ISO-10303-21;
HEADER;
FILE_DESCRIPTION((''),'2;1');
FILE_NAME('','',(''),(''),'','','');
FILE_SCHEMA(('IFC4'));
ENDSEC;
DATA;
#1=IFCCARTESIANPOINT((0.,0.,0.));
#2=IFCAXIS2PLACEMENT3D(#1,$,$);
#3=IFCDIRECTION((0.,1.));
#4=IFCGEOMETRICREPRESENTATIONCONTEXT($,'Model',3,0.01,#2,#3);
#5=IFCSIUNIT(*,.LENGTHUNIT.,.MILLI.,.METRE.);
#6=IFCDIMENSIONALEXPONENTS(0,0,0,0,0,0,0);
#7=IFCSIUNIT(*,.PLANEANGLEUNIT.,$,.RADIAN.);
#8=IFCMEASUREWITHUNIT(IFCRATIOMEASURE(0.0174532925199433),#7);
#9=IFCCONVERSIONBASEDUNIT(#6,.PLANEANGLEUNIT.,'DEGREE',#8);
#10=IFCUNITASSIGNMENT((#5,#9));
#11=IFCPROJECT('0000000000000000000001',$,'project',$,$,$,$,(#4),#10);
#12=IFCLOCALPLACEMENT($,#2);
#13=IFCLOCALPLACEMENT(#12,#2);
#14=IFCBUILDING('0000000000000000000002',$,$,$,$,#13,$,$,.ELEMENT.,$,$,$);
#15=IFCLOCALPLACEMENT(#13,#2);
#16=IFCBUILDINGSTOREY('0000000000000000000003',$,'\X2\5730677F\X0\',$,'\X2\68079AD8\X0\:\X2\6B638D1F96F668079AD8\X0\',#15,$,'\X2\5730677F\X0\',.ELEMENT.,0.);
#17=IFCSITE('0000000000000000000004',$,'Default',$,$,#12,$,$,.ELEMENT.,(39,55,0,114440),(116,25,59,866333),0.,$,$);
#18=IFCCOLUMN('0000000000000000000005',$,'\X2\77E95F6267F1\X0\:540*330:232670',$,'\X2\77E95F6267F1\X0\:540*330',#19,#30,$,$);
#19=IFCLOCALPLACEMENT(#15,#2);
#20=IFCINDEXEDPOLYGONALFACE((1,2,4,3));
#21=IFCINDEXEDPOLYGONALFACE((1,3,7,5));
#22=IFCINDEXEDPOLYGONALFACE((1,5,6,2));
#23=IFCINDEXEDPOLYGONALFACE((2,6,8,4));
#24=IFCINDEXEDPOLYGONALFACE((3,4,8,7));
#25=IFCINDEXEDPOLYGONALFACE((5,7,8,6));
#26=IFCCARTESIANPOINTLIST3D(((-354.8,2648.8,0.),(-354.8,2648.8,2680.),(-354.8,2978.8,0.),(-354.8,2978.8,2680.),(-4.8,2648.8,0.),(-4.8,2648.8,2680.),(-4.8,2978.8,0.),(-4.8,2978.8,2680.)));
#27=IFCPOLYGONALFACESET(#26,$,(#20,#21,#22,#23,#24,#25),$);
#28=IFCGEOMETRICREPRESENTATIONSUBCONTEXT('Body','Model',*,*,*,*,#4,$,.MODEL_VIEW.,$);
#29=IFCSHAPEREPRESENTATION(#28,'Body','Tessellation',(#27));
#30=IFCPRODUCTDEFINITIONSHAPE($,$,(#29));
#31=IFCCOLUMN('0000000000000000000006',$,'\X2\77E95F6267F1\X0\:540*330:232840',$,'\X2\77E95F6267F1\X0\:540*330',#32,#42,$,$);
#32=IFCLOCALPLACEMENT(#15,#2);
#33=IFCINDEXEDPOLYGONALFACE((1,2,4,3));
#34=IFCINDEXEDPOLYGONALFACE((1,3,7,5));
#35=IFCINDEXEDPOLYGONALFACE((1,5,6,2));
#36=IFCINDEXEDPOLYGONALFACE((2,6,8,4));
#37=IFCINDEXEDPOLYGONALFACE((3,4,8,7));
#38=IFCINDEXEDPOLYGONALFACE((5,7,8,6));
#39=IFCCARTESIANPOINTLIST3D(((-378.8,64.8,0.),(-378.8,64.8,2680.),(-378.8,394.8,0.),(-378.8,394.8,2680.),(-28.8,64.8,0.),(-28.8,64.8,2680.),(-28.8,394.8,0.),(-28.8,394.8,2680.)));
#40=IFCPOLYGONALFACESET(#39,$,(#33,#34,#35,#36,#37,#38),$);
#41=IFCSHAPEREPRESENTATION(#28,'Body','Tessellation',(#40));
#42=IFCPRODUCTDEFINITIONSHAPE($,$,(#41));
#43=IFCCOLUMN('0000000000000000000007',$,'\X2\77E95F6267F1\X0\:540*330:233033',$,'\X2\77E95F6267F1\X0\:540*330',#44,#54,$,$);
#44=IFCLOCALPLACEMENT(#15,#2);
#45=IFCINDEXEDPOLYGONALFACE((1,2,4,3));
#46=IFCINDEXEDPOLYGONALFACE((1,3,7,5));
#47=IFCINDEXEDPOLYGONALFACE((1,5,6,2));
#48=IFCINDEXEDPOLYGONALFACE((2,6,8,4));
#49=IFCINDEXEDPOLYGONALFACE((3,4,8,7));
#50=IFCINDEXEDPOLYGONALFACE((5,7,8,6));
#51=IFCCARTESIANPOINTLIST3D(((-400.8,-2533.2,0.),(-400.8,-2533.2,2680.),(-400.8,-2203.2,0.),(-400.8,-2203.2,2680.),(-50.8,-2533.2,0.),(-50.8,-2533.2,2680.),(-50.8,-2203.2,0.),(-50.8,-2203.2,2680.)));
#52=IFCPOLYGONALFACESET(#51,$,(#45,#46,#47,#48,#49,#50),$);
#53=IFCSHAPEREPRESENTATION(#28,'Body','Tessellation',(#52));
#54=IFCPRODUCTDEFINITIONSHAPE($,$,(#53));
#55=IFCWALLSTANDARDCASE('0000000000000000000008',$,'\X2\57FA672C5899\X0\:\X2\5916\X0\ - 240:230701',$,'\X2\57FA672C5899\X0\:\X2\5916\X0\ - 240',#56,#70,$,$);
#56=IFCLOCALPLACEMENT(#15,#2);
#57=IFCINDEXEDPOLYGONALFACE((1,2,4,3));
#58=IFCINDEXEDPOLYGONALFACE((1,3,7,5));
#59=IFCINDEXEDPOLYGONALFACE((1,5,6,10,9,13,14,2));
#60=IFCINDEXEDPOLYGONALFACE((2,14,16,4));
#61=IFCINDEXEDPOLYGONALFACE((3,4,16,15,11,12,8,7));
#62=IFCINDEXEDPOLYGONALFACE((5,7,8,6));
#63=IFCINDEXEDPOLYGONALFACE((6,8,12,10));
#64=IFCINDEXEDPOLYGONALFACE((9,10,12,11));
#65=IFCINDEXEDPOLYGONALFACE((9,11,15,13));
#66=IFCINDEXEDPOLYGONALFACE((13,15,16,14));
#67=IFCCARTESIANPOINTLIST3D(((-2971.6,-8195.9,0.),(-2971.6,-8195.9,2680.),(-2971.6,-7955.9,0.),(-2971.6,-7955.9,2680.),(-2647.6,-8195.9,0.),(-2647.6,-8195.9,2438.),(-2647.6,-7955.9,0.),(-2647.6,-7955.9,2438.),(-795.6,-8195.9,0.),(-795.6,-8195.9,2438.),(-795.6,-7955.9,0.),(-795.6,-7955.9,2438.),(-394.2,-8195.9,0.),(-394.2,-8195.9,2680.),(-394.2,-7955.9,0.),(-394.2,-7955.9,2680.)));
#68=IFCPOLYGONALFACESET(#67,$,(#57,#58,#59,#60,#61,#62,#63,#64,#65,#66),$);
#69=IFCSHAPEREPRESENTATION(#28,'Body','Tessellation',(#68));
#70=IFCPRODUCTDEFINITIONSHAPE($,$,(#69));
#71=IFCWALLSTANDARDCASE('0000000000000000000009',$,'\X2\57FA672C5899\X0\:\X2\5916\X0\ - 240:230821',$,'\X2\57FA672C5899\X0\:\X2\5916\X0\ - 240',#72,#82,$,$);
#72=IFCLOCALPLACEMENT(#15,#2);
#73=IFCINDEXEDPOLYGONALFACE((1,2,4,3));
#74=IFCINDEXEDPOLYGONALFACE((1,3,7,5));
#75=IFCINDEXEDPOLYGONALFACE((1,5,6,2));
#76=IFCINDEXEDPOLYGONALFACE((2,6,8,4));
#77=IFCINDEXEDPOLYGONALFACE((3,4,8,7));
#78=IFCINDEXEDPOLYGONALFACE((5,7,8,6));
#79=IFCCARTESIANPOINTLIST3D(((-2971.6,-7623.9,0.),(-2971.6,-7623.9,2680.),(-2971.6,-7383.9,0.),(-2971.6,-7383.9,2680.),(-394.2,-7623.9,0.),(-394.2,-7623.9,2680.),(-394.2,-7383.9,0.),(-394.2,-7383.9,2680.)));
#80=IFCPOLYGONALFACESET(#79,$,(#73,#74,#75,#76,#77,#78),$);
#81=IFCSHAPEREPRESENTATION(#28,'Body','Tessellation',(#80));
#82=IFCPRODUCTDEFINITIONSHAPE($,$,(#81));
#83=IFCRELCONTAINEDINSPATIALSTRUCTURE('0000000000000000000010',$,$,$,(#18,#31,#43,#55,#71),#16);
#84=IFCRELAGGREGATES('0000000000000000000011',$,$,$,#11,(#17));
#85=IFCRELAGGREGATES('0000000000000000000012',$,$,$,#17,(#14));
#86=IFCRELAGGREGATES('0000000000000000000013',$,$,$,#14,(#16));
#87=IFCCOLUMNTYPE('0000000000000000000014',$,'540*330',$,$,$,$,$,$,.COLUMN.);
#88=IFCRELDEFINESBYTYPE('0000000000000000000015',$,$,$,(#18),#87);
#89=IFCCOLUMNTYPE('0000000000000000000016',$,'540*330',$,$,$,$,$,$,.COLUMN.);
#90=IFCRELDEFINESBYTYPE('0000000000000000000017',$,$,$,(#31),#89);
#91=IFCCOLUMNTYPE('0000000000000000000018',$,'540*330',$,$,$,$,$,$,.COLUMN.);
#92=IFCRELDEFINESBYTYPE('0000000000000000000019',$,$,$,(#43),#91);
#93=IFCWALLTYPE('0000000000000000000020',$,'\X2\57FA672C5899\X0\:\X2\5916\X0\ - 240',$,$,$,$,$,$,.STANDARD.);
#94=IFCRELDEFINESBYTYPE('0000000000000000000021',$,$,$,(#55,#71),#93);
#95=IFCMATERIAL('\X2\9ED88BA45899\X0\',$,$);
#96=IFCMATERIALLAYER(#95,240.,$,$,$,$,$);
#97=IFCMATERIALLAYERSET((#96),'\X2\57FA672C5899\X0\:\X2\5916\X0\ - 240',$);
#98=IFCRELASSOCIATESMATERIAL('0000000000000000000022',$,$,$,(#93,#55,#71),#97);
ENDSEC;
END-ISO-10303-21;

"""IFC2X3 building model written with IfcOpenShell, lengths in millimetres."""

from ifc_helpers import new_model, entity, si_unit, converted_unit, direction, frame, frame_2d, origin, origin_2d_with_axis, place, context, subcontext, project, spatial, rectangle, extrude, source, transform, mapped, material, layer, layer_set, layer_usage, type_object, type_shapes, element, save


model = new_model("IFC2X3")

# Units and contexts
model_context = context("Model", 3, precision=0.01, world=origin(), true_north=direction((0.0, 1.0)))
body_context = subcontext(model_context, "Body", "Model", "MODEL_VIEW")
ifc_project = project(units=[si_unit("LENGTHUNIT", "METRE", prefix="MILLI"), converted_unit("PLANEANGLEUNIT", "DEGREE", entity("IfcRatioMeasure", 0.0174532925199433), si_unit("PLANEANGLEUNIT", "RADIAN"), dimensions=[0, 0, 0, 0, 0, 0, 0])], contexts=[model_context])

# Site, building, storey
site_placement = place(None, origin())
site = spatial("IfcSite", under=ifc_project, at=site_placement, Name="Default", CompositionType="ELEMENT", RefLatitude=(39, 55, 0, 114440), RefLongitude=(116, 25, 59, 866333), RefElevation=0.0)
building_placement = place(site_placement, origin())
building = spatial("IfcBuilding", under=site, at=building_placement, CompositionType="ELEMENT")
storey_placement = place(building_placement, origin())
storey = spatial("IfcBuildingStorey", under=building, at=storey_placement, Name="地板", ObjectType="标高:正负零标高", LongName="地板", CompositionType="ELEMENT", Elevation=0.0)

# Columns
ifc_material_1 = material(Name="默认墙")
column_type_1 = type_object("IfcColumnType", Name="540*330", PredefinedType="COLUMN")
shared_shape_1 = source(origin(), body_context, "Body", "SweptSolid", [
    extrude(rectangle(XDim=330.0, YDim=350.0, at=frame_2d((0.0, 0.0), x_axis=(1.0, 0.0))), frame((-179.8, 2813.8, 0.0), z_axis=(0.0, 0.0, 1.0), x_axis=(0.0, -1.0, 0.0)), (0.0, 0.0, 1.0), 2680.0),
])
type_shapes(column_type_1, [shared_shape_1])
column_1_placement = place(storey_placement, origin())
element("IfcColumn", 1, at=column_1_placement, inside=storey, type_object=column_type_1, Name="矩形柱:540*330:232670", ObjectType="矩形柱:540*330", context=body_context, shape_type="MappedRepresentation", body=[
    mapped(shared_shape_1, transform((0.0, 0.0, 0.0), scale=1.0)),
])
column_type_2 = type_object("IfcColumnType", Name="540*330", PredefinedType="COLUMN")
shared_shape_2 = source(origin(), body_context, "Body", "SweptSolid", [
    extrude(rectangle(XDim=330.0, YDim=350.0, at=origin_2d_with_axis()), frame((-203.8, 229.8, 0.0), z_axis=(0.0, 0.0, 1.0), x_axis=(0.0, -1.0, 0.0)), (0.0, 0.0, 1.0), 2680.0),
])
type_shapes(column_type_2, [shared_shape_2])
column_2_placement = place(storey_placement, origin())
element("IfcColumn", 2, at=column_2_placement, inside=storey, type_object=column_type_2, Name="矩形柱:540*330:232840", ObjectType="矩形柱:540*330", context=body_context, shape_type="MappedRepresentation", body=[
    mapped(shared_shape_2, transform((0.0, 0.0, 0.0), scale=1.0)),
])
column_type_3 = type_object("IfcColumnType", Name="540*330", PredefinedType="COLUMN")
shared_shape_3 = source(origin(), body_context, "Body", "SweptSolid", [
    extrude(rectangle(XDim=330.0, YDim=350.0, at=frame_2d((0.0, 0.0), x_axis=(1.0, 0.0))), frame((-225.8, -2368.2, 0.0), z_axis=(0.0, 0.0, 1.0), x_axis=(0.0, -1.0, 0.0)), (0.0, 0.0, 1.0), 2680.0),
])
type_shapes(column_type_3, [shared_shape_3])
column_3_placement = place(storey_placement, origin())
element("IfcColumn", 3, at=column_3_placement, inside=storey, type_object=column_type_3, Name="矩形柱:540*330:233033", ObjectType="矩形柱:540*330", context=body_context, shape_type="MappedRepresentation", body=[
    mapped(shared_shape_3, transform((0.0, 0.0, 0.0), scale=1.0)),
])

# Wall, opening
ifc_layer_1 = layer(ifc_material_1, 240.0)
ifc_layer_set_1 = layer_set([ifc_layer_1], Name="基本墙:外 - 240")
ifc_layer_usage_1 = layer_usage(ifc_layer_set_1, "AXIS2", "NEGATIVE", 120.0)
wall_type_1 = type_object("IfcWallType", Name="基本墙:外 - 240", PredefinedType="STANDARD", material=ifc_layer_set_1)
wall_1_placement = place(storey_placement, frame((-2971.6, -8075.9, 0.0)))
wall_1 = element("IfcWallStandardCase", 4, at=wall_1_placement, inside=storey, type_object=wall_type_1, material=ifc_layer_usage_1, Name="基本墙:外 - 240:230701", ObjectType="基本墙:外 - 240", context=body_context, shape_type="SweptSolid", body=[
    extrude(rectangle(XDim=2577.4, YDim=240.0, at=frame_2d((1288.7, 0.0), x_axis=(-1.0, 0.0))), origin(), (0.0, 0.0, 1.0), 2680.0),
])
opening_1_placement = place(wall_1_placement, frame((2176.0, 120.0, 0.0)))
element("IfcOpeningElement", 5, at=opening_1_placement, cuts=wall_1, ObjectType="Opening", context=body_context, shape_type="SweptSolid", body=[
    extrude(rectangle(XDim=2438.0, YDim=1852.0, at=frame_2d((1219.0, 926.0), x_axis=(1.0, 0.0))), frame((0.0, 0.0, 0.0), z_axis=(0.0, -1.0, 0.0), x_axis=(0.0, 0.0, 1.0)), (0.0, 0.0, 1.0), 240.0),
])

# Wall
ifc_layer_usage_2 = layer_usage(ifc_layer_set_1, "AXIS2", "NEGATIVE", 120.0)
wall_2_placement = place(storey_placement, frame((-2971.6, -7503.9, 0.0)))
element("IfcWallStandardCase", 6, at=wall_2_placement, inside=storey, type_object=wall_type_1, material=ifc_layer_usage_2, Name="基本墙:外 - 240:230821", ObjectType="基本墙:外 - 240", context=body_context, shape_type="SweptSolid", body=[
    extrude(rectangle(XDim=2577.4, YDim=240.0, at=frame_2d((1288.7, 0.0), x_axis=(-1.0, 0.0))), origin(), (0.0, 0.0, 1.0), 2680.0),
])

save(model, "model.ifc")
